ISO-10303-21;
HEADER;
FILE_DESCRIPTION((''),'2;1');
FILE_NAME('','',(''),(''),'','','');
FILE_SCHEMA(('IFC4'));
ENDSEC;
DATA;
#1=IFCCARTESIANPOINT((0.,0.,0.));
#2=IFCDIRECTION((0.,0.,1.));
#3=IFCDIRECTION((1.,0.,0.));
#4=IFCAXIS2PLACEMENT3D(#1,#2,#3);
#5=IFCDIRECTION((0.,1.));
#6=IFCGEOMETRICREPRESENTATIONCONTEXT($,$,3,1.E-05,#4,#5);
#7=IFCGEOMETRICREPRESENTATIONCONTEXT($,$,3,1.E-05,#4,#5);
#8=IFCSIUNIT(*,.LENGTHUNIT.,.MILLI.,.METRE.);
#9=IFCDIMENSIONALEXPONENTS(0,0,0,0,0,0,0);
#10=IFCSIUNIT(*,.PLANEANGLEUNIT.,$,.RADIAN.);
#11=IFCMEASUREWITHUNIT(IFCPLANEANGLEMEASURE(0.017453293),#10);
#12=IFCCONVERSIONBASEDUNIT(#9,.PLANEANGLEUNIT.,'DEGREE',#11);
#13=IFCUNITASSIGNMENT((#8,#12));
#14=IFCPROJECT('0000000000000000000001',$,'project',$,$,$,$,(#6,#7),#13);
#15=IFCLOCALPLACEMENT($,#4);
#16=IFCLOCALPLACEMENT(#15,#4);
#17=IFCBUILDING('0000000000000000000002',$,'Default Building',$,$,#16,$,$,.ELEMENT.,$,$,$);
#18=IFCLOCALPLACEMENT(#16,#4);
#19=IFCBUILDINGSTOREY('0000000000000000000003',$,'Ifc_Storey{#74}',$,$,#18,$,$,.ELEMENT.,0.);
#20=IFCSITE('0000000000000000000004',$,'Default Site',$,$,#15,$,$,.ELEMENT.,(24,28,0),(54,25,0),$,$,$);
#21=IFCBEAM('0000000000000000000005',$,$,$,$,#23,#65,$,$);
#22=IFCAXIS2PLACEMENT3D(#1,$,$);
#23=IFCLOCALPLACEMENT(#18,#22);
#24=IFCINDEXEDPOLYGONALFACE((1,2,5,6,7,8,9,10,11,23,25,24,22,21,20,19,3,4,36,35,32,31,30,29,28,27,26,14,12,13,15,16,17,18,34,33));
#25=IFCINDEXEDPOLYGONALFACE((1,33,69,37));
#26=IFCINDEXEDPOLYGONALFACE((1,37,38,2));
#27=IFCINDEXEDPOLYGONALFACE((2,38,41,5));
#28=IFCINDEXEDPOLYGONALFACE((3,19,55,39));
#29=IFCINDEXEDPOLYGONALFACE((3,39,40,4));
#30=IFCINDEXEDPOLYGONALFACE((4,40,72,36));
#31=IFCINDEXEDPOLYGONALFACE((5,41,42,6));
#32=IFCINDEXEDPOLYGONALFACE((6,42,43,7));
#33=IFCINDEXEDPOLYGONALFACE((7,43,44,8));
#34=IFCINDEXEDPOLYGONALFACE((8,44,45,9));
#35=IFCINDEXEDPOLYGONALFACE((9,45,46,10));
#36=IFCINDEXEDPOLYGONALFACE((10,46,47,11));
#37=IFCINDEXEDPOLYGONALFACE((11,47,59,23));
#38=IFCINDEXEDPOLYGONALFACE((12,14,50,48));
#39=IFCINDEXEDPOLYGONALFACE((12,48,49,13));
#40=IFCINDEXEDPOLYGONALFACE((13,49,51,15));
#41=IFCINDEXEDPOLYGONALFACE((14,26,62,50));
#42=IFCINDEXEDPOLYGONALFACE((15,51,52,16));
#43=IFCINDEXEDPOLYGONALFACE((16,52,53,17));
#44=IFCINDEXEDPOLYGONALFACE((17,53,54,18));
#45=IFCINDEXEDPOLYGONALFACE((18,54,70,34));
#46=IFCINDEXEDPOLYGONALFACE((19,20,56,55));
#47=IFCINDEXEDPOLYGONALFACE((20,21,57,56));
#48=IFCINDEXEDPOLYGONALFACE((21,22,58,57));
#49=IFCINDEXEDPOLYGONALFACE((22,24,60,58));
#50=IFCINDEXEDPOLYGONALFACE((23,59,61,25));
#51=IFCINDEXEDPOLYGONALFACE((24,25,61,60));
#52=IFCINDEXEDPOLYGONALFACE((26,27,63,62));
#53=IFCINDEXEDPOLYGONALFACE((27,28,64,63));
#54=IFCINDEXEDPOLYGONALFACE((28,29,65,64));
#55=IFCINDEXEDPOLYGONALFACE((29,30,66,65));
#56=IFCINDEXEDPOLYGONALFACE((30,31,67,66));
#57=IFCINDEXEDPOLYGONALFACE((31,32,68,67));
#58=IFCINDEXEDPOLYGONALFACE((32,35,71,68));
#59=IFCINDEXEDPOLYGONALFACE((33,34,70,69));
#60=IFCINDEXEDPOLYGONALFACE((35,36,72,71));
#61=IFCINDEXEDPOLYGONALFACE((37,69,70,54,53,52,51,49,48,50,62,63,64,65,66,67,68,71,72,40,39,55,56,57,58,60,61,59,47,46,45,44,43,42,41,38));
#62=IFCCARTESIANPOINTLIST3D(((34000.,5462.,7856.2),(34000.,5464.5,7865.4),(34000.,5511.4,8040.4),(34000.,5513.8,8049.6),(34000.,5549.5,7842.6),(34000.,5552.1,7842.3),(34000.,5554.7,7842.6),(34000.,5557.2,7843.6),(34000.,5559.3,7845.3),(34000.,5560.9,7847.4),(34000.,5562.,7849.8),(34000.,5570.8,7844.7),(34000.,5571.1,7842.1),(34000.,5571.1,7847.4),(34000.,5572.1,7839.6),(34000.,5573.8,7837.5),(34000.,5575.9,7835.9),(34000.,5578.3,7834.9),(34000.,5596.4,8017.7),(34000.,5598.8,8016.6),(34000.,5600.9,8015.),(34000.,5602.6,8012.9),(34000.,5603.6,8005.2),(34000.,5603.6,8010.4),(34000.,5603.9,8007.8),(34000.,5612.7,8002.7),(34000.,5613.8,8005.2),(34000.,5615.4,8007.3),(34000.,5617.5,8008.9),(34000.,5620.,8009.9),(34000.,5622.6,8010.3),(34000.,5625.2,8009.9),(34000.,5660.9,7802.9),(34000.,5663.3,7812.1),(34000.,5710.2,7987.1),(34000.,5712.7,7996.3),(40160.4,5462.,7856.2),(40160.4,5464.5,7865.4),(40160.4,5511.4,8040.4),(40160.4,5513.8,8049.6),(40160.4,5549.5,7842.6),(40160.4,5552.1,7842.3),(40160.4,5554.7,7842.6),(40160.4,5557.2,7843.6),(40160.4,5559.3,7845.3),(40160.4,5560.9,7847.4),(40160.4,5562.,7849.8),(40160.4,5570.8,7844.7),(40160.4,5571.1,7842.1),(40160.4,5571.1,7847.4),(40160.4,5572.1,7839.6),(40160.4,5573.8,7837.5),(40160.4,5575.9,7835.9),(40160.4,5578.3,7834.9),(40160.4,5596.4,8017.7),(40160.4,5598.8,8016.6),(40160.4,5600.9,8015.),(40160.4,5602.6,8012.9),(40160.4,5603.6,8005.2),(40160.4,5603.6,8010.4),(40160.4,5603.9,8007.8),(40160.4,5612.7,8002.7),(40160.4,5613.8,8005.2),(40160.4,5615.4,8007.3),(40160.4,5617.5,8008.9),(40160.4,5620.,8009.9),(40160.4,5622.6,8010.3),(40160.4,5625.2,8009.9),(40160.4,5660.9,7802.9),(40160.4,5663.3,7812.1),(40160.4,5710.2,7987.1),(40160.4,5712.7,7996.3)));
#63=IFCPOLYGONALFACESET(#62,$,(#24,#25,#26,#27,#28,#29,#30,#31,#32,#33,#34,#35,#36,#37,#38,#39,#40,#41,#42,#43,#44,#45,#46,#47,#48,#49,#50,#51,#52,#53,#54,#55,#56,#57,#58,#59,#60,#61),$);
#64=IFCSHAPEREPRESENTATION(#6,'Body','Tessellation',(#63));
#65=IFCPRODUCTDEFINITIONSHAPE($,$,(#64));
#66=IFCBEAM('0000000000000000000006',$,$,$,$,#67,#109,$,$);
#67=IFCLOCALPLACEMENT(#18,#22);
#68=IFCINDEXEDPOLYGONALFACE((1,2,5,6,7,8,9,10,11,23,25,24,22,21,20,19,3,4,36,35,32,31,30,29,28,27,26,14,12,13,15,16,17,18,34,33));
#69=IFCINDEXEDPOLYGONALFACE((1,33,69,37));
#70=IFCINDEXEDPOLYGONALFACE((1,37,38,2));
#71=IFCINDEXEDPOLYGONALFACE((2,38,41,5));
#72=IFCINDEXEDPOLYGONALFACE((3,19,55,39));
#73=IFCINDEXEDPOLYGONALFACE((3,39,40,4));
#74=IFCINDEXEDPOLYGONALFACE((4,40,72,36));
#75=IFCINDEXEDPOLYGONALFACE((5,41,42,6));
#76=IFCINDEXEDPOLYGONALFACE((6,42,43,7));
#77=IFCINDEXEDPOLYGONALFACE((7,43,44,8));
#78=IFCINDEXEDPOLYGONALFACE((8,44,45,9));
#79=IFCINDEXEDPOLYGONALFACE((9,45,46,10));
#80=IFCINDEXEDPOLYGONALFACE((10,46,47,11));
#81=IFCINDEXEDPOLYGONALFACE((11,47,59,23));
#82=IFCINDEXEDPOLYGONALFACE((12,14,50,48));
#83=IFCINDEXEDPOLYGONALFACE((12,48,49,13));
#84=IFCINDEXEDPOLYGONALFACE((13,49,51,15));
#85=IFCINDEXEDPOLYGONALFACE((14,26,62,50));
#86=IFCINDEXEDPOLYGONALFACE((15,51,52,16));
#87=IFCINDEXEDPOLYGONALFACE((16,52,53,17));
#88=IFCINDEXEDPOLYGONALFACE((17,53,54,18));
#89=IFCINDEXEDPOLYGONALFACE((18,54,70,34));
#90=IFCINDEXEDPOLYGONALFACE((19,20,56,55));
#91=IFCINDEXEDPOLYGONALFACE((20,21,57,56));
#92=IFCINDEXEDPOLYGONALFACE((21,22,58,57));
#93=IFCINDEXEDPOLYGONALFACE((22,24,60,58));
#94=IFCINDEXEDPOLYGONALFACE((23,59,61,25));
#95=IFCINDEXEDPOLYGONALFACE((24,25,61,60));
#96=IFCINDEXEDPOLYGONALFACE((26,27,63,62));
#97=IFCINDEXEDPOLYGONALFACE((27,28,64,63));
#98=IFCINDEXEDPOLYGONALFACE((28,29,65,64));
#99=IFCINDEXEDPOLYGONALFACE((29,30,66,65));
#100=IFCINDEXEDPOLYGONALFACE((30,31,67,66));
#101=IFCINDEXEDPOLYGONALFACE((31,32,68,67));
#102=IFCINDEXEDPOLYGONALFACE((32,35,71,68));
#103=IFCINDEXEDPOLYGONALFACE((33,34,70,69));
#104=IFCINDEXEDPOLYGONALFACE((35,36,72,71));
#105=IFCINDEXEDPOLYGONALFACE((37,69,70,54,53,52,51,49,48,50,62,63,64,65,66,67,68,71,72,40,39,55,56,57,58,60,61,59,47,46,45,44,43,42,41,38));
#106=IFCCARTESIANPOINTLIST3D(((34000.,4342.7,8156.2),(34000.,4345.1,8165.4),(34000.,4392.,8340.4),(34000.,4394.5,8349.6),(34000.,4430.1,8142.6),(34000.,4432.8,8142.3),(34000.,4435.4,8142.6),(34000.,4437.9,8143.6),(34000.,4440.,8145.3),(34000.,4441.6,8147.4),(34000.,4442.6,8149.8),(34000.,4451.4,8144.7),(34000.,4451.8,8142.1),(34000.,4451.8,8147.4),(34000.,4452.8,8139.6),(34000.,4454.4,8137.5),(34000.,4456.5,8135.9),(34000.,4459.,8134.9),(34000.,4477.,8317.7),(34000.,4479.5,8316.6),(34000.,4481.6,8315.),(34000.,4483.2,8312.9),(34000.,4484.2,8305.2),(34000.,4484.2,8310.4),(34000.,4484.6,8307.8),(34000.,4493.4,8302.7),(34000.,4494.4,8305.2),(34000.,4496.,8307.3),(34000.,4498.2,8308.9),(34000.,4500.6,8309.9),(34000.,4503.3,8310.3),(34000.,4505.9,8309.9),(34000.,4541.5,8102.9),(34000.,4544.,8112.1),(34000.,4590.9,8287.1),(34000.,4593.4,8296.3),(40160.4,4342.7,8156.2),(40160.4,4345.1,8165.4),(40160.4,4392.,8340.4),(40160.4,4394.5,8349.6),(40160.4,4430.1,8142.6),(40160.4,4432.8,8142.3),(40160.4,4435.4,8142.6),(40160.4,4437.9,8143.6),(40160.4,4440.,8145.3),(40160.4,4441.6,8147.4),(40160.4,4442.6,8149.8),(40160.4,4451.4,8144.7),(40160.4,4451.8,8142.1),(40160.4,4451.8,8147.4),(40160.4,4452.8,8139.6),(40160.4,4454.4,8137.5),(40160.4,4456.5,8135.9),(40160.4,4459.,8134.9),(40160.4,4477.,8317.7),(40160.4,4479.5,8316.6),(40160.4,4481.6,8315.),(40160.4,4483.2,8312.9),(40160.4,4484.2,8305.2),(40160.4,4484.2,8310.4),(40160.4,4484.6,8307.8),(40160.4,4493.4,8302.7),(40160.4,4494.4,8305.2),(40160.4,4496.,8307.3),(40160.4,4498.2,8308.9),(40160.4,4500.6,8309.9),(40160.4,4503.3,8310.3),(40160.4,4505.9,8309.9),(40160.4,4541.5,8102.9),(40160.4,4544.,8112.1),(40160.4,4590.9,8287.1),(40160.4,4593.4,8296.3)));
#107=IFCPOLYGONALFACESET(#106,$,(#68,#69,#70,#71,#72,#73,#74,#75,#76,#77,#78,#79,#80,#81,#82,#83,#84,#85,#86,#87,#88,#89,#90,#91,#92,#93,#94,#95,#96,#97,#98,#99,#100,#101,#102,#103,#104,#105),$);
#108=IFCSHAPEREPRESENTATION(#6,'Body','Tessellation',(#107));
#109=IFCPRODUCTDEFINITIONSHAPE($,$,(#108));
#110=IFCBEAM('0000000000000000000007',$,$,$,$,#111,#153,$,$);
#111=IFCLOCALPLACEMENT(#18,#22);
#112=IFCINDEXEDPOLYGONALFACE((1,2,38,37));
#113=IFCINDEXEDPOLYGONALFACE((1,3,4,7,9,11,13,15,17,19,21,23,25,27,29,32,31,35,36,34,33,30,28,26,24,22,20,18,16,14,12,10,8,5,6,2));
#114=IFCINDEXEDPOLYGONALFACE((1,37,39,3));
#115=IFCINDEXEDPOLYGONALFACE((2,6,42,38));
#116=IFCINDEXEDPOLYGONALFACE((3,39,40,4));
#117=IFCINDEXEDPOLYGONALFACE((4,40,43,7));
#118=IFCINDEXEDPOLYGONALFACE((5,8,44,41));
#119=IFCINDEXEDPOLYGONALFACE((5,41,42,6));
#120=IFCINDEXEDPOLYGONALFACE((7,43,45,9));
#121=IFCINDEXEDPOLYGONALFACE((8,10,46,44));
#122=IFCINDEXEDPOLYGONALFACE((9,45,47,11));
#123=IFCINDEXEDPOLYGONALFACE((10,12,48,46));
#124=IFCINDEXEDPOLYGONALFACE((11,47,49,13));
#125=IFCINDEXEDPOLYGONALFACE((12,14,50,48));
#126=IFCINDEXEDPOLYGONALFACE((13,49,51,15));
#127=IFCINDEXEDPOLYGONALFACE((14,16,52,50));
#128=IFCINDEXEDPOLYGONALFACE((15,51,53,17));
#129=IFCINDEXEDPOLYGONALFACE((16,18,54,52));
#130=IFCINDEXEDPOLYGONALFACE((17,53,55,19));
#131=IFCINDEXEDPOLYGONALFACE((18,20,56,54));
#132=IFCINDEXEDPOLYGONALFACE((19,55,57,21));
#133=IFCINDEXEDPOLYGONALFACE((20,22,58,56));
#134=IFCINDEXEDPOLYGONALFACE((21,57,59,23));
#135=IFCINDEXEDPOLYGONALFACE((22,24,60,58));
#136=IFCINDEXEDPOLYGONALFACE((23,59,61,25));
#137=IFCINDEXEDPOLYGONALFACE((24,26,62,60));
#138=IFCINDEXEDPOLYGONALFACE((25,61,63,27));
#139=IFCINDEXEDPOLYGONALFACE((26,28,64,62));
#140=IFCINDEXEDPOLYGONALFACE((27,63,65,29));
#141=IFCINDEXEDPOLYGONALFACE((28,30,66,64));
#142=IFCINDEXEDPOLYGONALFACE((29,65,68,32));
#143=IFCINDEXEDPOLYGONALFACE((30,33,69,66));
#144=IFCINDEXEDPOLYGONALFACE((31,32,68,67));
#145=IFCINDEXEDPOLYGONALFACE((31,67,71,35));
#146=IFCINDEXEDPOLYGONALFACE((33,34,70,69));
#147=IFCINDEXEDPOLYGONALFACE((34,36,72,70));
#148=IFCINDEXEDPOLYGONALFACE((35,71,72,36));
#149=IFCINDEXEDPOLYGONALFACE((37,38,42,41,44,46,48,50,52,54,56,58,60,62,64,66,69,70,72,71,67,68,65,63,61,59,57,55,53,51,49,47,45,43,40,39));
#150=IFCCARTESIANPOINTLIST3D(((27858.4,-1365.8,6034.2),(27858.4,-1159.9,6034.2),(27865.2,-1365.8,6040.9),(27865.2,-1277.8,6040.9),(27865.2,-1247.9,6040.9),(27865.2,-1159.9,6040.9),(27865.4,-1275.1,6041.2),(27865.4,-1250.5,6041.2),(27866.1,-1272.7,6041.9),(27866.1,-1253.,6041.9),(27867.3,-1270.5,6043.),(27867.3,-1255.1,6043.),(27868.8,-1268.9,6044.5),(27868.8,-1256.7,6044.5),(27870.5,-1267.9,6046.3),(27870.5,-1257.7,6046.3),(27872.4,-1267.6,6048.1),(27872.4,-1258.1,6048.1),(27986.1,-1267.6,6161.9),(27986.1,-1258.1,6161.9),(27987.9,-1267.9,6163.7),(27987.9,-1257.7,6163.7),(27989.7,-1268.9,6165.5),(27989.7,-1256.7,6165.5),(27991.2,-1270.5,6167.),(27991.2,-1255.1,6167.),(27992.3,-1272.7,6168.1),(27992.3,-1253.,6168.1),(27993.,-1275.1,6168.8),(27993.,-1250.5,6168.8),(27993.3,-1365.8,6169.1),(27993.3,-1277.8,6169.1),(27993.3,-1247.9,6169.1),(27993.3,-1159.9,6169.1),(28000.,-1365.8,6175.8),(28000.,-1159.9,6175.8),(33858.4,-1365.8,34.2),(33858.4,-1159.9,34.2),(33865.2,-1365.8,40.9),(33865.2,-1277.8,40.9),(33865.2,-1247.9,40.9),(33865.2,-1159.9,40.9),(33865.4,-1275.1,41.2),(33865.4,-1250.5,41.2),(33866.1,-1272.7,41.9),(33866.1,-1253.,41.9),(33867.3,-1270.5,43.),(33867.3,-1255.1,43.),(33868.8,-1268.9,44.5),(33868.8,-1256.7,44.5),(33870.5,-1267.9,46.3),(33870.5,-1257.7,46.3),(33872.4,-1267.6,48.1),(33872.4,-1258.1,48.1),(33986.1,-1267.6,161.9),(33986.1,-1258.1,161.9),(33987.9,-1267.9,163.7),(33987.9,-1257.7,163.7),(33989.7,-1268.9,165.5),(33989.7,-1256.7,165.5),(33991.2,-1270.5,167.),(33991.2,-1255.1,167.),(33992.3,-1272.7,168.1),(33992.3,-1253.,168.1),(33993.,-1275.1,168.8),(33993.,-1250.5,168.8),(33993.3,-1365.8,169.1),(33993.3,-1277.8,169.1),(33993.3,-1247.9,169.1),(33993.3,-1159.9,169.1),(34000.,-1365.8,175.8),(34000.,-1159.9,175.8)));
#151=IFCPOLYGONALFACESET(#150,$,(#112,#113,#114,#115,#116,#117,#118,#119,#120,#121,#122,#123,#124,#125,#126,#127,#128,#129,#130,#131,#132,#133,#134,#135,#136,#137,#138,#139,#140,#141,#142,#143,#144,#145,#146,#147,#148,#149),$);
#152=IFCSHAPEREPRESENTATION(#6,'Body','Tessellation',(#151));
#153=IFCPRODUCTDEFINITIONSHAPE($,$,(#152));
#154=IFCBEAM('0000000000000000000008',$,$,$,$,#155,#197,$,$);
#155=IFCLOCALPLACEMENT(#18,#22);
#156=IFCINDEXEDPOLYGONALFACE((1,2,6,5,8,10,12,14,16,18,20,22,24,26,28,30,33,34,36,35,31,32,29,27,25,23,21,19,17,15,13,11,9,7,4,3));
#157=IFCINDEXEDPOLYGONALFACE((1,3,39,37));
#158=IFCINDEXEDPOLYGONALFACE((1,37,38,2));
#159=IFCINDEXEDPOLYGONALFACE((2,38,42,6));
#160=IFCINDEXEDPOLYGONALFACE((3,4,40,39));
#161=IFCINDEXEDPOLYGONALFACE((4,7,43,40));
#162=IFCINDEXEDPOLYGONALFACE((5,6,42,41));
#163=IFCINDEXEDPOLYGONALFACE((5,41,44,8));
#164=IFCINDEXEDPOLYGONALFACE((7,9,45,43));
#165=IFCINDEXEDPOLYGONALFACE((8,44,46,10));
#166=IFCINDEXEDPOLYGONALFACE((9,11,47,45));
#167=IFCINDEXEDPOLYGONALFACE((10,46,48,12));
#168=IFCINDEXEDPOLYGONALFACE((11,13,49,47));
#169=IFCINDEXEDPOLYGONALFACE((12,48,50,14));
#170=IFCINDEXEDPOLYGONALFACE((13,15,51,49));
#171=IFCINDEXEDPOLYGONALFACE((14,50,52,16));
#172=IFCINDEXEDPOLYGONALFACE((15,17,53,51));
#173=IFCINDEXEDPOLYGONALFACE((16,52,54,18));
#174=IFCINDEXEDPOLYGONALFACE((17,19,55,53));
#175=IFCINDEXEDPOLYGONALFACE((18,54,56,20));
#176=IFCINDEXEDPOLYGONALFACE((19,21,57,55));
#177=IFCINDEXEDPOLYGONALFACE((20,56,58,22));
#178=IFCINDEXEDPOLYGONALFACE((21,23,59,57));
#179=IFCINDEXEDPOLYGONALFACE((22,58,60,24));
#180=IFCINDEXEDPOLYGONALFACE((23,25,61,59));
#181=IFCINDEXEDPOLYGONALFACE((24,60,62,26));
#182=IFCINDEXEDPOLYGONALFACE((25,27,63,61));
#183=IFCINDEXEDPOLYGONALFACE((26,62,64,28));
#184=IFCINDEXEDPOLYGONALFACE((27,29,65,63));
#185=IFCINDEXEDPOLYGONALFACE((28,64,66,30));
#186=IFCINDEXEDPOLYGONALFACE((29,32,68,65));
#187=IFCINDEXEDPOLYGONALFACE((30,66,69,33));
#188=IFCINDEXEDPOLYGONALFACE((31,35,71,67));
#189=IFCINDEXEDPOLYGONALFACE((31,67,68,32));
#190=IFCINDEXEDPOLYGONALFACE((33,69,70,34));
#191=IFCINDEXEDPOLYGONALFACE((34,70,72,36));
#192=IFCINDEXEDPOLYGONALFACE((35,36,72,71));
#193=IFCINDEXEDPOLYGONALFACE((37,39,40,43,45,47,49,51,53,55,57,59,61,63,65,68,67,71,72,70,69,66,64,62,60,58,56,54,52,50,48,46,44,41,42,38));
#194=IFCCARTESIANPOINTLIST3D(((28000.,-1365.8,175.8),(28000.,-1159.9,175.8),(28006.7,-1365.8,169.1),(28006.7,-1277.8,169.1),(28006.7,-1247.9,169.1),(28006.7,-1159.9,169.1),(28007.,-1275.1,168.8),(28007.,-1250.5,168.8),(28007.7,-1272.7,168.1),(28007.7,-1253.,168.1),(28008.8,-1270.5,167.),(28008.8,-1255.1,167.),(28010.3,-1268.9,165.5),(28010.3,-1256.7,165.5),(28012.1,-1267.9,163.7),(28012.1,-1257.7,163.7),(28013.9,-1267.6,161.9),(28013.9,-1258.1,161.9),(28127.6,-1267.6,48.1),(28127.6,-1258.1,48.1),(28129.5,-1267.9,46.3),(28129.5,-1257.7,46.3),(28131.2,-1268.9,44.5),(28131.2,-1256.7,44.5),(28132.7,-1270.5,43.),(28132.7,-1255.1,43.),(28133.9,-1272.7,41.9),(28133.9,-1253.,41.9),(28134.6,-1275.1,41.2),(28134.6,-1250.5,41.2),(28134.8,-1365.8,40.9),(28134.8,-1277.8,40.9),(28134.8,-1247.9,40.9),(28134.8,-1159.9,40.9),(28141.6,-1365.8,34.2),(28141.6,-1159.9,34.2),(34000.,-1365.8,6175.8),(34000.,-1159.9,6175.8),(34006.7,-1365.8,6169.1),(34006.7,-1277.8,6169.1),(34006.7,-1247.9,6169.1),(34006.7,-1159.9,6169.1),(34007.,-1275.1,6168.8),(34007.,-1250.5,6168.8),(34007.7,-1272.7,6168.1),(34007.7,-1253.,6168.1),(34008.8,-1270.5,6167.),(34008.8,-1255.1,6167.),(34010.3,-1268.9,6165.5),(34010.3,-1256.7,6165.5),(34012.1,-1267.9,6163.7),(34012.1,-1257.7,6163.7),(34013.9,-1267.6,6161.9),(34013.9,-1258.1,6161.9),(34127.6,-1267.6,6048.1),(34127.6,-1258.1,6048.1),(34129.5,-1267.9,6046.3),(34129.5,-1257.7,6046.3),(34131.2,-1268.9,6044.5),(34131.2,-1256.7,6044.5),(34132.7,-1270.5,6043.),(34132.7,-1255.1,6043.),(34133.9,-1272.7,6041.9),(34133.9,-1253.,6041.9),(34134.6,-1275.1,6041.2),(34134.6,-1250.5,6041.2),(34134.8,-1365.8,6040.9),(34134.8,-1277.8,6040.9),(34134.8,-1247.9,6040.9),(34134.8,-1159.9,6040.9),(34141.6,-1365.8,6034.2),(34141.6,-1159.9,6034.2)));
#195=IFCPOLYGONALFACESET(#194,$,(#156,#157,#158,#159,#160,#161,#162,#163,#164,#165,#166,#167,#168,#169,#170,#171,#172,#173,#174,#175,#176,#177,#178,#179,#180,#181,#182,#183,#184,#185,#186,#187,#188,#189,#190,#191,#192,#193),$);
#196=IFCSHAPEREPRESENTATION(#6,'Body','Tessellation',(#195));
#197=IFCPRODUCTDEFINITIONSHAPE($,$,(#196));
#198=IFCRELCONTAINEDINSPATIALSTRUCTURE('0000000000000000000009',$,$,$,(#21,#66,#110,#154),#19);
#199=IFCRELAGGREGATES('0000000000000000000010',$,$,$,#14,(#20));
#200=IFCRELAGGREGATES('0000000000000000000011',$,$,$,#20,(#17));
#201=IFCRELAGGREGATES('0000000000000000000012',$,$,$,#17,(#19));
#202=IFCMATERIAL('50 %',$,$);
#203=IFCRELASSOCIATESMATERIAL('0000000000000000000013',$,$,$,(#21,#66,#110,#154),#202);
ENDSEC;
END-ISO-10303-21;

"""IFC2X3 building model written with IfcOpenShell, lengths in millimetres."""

from ifc_helpers import new_model, entity, si_unit, converted_unit, direction, frame, origin_with_axes, origin_2d_with_axis, place, context, project, spatial, i_section, extrude, material, element, save


model = new_model("IFC2X3")

# Units and contexts
context_of_model_1 = context(None, 3, precision=1e-05, world=origin_with_axes(), true_north=direction((0.0, 1.0)))
context_of_model_2 = context(None, 3, precision=1e-05, world=origin_with_axes(), true_north=direction((0.0, 1.0)))
ifc_project = project(units=[si_unit("LENGTHUNIT", "METRE", prefix="MILLI"), converted_unit("PLANEANGLEUNIT", "DEGREE", entity("IfcPlaneAngleMeasure", 0.017453293), si_unit("PLANEANGLEUNIT", "RADIAN"), dimensions=[0, 0, 0, 0, 0, 0, 0])], contexts=[context_of_model_1, context_of_model_2])

# Site, building, storey
site_placement = place(None, origin_with_axes())
site = spatial("IfcSite", under=ifc_project, at=site_placement, Name="Default Site", CompositionType="ELEMENT", RefLatitude=(24, 28, 0), RefLongitude=(54, 25, 0))
building_placement = place(site_placement, origin_with_axes())
building = spatial("IfcBuilding", under=site, at=building_placement, Name="Default Building", CompositionType="ELEMENT")
storey_placement = place(building_placement, origin_with_axes())
storey = spatial("IfcBuildingStorey", under=building, at=storey_placement, Name="Ifc_Storey{#74}", CompositionType="ELEMENT", Elevation=0.0)

# Shared definitions
ifc_material_1 = material(Name="50 %")

# Beams
for number, where, z_axis, x_axis in (
    (1, (34000.0, 5587.4, 7926.3), (0.0, 0.258819, 0.965926), (1.0, 0.0, 0.0)),
    (2, (34000.0, 4468.0, 8226.3), (0.0, 0.258819, 0.965926), (1.0, 0.0, 0.0)),
):
    element("IfcBeam", number, at=place(storey_placement, frame(where, z_axis=z_axis, x_axis=x_axis)), inside=storey, material=ifc_material_1, context=context_of_model_1, shape_type="SweptSolid", body=[
        extrude(i_section(OverallWidth=205.9, OverallDepth=200.2, WebThickness=9.5, FlangeThickness=9.5, FilletRadius=10.2, at=origin_2d_with_axis()), frame((0.0, 0.0, 0.0), z_axis=(1.0, 0.0, 0.0), x_axis=(0.0, 1.0, 0.0)), (0.0, 0.0, 1.0), 6160.4),
    ])
beam_1_placement = place(storey_placement, frame((33929.2, -1262.8, 105.0), z_axis=(0.0, 0.0, 1.0), x_axis=(-1.0, 0.0, 0.0)))
element("IfcBeam", 3, at=beam_1_placement, inside=storey, material=ifc_material_1, context=context_of_model_1, shape_type="SweptSolid", body=[
    extrude(i_section(OverallWidth=205.9, OverallDepth=200.2, WebThickness=9.5, FlangeThickness=9.5, FilletRadius=10.2, at=origin_2d_with_axis()), frame((0.0, 0.0, 0.0), z_axis=(0.707107, 0.0, 0.707107), x_axis=(0.0, 1.0, 0.0)), (0.0, 0.0, 1.0), 8485.3),
])
beam_2_placement = place(storey_placement, frame((28070.8, -1262.8, 105.0), z_axis=(0.0, 0.0, 1.0), x_axis=(-1.0, 0.0, 0.0)))
element("IfcBeam", 4, at=beam_2_placement, inside=storey, material=ifc_material_1, context=context_of_model_1, shape_type="SweptSolid", body=[
    extrude(i_section(OverallWidth=205.9, OverallDepth=200.2, WebThickness=9.5, FlangeThickness=9.5, FilletRadius=10.2, at=origin_2d_with_axis()), frame((0.0, 0.0, 0.0), z_axis=(-0.707107, 0.0, 0.707107), x_axis=(0.0, 1.0, 0.0)), (0.0, 0.0, 1.0), 8485.3),
])

save(model, "model.ifc")
